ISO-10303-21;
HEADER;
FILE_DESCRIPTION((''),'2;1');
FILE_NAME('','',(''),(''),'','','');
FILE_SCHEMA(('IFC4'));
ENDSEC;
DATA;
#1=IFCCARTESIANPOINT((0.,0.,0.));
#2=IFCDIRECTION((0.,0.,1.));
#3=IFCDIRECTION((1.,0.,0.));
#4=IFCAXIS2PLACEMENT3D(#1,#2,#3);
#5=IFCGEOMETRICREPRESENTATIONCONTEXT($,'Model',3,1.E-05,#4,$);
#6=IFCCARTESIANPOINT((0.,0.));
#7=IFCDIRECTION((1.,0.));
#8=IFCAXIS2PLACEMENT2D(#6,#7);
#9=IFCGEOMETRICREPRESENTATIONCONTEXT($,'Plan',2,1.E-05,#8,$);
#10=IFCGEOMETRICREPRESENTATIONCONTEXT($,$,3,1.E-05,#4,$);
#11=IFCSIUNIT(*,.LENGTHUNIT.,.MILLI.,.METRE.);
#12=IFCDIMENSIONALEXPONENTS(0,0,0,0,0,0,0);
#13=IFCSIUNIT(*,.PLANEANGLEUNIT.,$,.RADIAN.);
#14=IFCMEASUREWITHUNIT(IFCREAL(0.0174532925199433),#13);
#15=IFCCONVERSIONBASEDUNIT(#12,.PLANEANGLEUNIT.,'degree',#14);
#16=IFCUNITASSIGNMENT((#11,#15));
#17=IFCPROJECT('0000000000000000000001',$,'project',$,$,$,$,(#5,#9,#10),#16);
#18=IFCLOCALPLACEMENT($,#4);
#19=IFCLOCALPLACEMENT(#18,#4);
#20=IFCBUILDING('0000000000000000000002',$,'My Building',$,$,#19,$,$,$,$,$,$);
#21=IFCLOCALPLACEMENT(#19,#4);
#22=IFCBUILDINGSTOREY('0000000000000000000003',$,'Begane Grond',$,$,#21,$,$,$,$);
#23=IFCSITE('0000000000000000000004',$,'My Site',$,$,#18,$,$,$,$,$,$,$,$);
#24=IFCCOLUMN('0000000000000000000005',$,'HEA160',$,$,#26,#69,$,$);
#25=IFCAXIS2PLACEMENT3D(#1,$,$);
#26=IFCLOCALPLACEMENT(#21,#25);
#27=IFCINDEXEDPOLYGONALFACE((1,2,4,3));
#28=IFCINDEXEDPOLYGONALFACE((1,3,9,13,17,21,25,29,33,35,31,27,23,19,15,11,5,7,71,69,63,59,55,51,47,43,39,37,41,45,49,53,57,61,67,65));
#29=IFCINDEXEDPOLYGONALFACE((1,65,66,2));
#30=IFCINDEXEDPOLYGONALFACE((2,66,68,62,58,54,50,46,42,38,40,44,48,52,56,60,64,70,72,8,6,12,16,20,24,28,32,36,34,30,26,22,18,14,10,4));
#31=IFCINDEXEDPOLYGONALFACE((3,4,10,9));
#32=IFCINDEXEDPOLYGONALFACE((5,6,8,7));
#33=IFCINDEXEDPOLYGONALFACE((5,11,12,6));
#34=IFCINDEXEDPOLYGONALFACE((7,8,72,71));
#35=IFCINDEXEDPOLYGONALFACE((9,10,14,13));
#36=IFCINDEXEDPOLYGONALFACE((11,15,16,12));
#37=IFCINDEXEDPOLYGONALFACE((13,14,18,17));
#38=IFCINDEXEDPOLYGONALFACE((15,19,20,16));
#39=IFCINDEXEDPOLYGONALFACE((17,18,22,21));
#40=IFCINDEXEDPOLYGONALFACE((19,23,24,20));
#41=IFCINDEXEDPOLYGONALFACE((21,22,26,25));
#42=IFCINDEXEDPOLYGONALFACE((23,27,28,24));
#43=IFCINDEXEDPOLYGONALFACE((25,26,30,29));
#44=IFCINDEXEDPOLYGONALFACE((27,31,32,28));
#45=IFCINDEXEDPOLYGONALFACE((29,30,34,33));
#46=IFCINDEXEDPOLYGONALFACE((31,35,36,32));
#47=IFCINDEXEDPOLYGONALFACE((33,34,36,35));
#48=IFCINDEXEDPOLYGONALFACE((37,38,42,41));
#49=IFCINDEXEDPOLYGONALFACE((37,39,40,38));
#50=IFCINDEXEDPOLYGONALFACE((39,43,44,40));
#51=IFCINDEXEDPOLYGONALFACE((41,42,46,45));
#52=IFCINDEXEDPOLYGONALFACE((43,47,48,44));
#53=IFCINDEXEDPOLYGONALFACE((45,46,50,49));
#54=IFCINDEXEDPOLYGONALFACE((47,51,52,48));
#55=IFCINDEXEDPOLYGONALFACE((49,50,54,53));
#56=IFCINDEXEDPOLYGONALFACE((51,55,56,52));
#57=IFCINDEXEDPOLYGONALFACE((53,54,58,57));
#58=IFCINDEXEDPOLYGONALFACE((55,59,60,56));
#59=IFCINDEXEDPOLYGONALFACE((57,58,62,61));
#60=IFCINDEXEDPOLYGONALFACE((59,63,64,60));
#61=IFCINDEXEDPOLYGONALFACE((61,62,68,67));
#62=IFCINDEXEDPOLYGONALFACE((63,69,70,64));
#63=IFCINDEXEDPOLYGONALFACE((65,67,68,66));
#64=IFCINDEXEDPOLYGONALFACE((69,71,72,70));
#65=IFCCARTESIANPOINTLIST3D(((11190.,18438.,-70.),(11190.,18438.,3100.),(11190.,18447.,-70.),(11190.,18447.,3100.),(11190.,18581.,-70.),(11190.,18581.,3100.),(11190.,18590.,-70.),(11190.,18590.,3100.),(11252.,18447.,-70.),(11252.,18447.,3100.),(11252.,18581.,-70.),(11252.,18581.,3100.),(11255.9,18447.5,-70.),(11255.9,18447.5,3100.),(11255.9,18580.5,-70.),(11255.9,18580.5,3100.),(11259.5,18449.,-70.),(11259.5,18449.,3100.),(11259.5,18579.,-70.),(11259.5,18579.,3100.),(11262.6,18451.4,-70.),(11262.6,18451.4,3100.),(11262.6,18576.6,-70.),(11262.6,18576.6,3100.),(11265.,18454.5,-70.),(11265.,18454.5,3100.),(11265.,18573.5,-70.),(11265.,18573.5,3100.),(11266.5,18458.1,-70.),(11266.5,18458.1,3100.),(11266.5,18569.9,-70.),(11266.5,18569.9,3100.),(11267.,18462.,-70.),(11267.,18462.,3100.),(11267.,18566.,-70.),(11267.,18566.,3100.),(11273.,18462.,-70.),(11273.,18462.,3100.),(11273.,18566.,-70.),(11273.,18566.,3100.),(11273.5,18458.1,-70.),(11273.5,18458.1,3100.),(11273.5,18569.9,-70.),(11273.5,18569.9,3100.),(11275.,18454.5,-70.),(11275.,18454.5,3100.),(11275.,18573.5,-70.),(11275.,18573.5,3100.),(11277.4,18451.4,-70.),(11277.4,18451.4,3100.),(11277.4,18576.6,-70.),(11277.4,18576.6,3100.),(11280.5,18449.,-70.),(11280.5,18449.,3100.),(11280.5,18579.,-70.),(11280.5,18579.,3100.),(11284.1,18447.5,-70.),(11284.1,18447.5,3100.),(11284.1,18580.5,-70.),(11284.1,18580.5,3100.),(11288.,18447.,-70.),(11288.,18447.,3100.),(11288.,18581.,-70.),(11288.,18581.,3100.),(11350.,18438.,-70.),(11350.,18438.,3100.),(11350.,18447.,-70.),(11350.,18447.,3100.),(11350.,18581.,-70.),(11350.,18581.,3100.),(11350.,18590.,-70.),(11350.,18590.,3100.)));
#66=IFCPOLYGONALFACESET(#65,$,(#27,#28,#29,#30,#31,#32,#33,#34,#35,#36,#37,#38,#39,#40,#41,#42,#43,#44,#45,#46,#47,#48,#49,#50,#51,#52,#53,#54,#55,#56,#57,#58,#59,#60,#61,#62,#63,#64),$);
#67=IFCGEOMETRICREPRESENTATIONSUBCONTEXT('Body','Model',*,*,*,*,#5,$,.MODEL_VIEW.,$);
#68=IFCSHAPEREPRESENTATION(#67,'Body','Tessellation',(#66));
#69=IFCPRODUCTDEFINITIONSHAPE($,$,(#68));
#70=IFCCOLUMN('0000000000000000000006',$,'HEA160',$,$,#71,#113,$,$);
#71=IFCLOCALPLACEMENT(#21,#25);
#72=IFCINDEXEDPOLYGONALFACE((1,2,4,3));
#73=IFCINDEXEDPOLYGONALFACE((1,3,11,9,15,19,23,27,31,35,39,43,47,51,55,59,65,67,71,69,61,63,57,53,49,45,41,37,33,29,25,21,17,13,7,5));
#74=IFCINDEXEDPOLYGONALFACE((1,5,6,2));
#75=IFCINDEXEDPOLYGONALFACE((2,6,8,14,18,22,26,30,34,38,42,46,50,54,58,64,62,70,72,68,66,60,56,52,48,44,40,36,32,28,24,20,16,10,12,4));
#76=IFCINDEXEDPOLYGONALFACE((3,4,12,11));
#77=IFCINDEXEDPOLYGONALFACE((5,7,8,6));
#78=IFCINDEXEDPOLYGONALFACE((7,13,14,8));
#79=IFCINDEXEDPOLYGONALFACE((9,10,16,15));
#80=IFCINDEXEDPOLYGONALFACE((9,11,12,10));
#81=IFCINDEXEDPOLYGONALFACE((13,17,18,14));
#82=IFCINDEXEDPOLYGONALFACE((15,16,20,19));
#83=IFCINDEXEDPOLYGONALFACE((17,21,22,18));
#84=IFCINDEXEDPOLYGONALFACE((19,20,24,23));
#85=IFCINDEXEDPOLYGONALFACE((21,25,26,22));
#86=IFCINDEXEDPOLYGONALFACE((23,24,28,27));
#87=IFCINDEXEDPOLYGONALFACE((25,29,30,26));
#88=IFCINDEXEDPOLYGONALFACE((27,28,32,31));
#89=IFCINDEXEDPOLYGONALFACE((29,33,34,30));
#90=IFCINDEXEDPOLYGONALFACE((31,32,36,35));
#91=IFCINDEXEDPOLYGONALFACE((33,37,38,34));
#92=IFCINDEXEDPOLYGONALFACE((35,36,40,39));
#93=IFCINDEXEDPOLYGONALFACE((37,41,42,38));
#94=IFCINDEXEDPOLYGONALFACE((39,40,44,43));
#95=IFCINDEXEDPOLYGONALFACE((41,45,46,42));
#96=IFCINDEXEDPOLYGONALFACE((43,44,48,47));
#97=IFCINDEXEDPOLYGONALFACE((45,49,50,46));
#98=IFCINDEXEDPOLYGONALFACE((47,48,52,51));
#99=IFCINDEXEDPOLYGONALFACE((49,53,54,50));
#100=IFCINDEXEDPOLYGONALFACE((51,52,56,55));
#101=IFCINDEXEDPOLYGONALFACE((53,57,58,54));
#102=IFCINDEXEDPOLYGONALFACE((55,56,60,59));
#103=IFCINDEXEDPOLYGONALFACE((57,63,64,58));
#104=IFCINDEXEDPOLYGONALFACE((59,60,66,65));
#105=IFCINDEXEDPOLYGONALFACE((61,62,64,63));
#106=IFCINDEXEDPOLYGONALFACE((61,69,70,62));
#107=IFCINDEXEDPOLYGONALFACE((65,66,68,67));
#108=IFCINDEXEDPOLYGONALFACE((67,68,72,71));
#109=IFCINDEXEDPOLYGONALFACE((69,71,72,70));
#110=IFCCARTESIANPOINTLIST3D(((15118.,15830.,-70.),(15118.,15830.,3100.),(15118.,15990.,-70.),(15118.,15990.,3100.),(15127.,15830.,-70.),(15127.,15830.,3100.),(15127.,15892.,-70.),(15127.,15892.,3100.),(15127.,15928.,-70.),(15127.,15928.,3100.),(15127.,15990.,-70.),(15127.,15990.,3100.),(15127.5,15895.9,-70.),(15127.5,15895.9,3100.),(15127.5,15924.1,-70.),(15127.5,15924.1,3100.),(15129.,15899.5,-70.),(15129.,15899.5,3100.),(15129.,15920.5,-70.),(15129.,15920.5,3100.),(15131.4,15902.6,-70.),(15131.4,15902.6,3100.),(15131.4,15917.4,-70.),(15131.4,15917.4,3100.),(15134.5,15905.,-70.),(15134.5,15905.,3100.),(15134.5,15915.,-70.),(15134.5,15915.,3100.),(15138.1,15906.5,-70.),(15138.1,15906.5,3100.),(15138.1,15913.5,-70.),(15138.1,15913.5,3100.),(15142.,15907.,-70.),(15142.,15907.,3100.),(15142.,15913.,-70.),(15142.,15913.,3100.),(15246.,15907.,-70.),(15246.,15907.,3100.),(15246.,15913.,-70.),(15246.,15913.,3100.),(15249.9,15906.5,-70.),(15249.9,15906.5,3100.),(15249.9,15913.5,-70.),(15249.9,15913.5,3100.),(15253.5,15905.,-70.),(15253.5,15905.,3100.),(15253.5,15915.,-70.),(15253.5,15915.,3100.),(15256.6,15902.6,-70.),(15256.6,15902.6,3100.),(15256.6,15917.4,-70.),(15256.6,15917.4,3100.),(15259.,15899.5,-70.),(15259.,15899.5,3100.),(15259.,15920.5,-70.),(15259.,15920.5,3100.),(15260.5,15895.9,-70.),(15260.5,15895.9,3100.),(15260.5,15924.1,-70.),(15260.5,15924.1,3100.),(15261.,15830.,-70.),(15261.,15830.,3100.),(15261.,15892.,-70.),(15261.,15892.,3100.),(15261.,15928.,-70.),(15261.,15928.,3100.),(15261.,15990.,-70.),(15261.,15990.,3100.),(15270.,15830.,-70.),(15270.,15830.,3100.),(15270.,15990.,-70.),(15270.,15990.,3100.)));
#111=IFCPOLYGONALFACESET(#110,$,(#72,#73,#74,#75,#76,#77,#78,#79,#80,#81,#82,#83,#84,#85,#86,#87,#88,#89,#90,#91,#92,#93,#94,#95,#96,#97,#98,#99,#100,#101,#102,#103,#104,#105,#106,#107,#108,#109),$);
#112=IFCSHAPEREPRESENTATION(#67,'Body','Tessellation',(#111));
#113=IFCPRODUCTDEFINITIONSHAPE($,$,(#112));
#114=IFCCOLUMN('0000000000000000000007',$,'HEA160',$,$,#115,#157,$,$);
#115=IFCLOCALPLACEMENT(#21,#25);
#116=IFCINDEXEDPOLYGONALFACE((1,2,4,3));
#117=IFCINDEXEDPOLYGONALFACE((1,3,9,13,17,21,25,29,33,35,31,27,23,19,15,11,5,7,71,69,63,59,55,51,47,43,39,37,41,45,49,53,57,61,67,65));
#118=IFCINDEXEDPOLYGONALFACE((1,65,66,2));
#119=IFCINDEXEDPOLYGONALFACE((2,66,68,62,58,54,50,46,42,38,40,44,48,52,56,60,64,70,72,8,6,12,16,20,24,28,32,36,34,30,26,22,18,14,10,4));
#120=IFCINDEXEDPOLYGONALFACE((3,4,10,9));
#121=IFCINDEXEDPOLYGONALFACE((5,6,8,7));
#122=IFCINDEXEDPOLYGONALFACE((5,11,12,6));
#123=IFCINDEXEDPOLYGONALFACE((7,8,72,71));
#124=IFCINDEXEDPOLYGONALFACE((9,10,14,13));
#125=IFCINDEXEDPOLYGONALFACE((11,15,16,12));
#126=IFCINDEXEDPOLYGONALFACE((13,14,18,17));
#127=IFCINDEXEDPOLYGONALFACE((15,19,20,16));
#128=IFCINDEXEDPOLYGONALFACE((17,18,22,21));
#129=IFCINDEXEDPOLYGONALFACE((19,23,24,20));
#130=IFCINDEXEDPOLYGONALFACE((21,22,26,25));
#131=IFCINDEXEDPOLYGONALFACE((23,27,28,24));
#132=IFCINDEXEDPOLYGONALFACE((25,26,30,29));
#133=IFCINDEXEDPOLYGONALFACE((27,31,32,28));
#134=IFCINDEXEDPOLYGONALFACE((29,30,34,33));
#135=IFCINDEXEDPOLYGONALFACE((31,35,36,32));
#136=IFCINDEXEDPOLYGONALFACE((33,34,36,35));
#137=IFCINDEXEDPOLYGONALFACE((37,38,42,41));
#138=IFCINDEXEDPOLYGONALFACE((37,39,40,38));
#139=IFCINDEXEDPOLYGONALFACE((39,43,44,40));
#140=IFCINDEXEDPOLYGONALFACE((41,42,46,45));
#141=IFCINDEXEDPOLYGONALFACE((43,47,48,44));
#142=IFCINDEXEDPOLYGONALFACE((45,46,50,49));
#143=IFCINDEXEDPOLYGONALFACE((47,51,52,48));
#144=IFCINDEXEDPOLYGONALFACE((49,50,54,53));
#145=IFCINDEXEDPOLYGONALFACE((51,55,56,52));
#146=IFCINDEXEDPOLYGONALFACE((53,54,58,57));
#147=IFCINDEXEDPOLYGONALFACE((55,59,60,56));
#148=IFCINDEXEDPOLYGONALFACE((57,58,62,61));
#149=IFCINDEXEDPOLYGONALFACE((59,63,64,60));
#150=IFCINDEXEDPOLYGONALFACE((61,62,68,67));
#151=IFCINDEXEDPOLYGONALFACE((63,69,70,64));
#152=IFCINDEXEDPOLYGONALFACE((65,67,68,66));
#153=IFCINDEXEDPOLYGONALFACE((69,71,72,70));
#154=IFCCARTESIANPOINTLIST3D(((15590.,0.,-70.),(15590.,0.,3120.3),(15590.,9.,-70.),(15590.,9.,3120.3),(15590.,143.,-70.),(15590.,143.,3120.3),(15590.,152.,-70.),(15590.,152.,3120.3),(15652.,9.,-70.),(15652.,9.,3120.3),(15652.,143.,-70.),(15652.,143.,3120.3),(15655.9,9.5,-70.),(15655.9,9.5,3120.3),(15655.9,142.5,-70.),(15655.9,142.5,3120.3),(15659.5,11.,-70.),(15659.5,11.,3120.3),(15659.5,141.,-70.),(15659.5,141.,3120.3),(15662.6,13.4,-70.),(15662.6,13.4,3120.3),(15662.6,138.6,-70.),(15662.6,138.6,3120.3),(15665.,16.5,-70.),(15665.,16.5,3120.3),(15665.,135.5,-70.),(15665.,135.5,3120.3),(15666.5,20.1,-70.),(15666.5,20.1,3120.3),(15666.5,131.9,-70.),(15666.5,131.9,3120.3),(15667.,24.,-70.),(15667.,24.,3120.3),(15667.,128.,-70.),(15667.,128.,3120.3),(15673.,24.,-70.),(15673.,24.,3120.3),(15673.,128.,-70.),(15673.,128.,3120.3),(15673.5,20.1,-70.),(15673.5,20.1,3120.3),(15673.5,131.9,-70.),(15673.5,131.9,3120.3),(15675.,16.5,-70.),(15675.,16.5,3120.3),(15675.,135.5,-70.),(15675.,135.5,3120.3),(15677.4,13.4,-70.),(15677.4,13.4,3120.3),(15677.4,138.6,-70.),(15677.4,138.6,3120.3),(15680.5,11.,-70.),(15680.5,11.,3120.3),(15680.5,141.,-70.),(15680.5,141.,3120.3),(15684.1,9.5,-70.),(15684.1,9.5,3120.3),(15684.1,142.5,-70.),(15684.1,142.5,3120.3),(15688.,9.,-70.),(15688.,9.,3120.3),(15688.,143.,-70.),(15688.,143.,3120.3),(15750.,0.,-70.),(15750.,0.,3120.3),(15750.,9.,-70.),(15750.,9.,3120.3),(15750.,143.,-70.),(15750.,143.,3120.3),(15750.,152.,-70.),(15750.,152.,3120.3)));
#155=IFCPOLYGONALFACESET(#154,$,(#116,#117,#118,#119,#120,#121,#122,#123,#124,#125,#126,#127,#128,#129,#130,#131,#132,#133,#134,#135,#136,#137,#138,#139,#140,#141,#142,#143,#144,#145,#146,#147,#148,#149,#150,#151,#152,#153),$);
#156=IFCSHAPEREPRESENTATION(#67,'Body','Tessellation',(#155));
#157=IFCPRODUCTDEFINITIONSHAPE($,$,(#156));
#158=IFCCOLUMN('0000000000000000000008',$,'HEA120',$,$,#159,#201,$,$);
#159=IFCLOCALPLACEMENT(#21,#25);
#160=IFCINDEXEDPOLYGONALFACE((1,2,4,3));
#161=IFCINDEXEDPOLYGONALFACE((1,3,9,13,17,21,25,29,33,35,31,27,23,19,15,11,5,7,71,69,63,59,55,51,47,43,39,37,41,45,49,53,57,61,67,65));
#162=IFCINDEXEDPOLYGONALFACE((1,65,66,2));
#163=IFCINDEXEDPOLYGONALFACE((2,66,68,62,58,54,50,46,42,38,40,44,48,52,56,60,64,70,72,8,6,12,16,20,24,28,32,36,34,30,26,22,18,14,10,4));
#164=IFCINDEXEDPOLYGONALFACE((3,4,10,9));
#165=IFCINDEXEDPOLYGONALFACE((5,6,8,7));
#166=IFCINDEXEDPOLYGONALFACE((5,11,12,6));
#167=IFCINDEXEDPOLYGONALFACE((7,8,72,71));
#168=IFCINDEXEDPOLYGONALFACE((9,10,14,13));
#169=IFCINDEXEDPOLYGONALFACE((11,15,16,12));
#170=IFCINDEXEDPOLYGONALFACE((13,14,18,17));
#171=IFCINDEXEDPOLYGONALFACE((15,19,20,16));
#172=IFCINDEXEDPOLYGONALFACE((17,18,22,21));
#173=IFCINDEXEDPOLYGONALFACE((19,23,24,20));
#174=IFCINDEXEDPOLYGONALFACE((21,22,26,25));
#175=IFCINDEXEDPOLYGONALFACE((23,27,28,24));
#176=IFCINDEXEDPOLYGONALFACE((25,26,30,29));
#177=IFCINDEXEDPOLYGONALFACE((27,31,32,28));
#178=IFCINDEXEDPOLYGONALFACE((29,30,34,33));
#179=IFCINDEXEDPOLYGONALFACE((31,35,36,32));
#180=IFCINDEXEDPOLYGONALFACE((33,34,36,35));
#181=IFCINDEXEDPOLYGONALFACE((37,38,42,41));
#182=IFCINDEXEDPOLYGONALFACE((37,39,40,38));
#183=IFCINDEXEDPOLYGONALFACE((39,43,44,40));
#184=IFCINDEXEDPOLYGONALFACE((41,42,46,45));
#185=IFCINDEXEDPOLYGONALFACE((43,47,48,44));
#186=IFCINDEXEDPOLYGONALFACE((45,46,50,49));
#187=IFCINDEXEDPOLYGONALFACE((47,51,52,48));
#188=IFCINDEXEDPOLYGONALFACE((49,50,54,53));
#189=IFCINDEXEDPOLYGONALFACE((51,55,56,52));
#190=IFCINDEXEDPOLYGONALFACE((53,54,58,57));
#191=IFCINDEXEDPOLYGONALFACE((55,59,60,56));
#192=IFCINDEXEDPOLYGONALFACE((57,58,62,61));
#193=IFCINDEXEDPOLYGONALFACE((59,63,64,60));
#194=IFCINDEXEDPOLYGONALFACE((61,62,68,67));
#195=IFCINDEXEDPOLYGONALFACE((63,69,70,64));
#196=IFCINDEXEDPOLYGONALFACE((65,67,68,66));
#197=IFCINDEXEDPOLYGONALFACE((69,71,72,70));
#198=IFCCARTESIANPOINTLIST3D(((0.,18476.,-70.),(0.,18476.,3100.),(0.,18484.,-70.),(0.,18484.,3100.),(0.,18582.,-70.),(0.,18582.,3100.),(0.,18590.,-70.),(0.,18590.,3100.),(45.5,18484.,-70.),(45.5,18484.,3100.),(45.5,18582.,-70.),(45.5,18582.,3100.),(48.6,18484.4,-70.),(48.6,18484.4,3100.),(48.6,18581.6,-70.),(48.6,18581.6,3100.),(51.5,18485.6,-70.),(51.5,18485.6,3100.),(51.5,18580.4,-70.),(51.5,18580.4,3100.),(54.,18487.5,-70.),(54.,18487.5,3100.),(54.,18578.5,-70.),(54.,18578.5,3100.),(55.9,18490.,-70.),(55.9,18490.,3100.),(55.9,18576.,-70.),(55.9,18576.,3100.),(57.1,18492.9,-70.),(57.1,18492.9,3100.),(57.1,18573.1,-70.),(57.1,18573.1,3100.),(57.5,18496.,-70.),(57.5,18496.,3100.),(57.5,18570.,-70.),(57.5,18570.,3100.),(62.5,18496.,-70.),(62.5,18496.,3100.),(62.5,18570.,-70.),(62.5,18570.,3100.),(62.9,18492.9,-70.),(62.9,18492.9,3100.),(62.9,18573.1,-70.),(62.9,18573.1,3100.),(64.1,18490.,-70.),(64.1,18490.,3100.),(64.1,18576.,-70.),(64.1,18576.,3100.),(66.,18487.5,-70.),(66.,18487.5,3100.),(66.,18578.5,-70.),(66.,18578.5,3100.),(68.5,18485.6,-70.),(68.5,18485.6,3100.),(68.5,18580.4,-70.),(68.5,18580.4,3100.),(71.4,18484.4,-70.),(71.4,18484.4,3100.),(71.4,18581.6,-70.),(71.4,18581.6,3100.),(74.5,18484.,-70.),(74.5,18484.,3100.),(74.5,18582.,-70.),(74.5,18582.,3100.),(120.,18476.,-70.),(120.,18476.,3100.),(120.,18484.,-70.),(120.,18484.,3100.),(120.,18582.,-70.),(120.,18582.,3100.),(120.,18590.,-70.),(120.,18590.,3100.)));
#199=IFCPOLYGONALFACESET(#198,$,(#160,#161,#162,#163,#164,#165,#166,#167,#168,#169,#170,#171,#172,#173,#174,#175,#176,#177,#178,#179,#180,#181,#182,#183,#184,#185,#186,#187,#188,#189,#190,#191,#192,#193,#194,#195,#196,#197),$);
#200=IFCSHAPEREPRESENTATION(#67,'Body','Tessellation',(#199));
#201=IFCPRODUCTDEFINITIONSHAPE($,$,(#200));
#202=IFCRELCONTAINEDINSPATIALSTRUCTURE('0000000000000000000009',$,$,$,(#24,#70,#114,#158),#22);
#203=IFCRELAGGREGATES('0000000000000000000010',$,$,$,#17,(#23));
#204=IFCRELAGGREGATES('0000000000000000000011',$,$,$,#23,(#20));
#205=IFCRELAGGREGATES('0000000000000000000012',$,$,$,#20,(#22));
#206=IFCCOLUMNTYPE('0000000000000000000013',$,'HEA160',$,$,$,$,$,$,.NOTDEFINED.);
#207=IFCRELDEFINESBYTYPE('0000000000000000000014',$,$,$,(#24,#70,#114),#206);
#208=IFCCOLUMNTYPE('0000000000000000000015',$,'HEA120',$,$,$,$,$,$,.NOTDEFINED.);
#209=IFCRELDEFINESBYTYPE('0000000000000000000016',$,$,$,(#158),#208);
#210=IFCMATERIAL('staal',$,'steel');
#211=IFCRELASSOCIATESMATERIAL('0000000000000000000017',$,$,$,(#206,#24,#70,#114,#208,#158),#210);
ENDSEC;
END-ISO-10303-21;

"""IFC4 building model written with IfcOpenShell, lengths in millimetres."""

from ifc_helpers import new_model, entity, si_unit, converted_unit, frame, origin_with_axes, origin_2d_with_axis, place, context, subcontext, project, spatial, i_section, extrude, material, material_profile, profile_set, profile_usage, type_object, element, save


model = new_model("IFC4")

# Units and contexts
model_context = context("Model", 3, precision=1e-05, world=origin_with_axes())
plan_context = context("Plan", 2, precision=1e-05, world=origin_2d_with_axis())
context_of_model = context(None, 3, precision=1e-05, world=origin_with_axes())
body_context = subcontext(model_context, "Body", "Model", "MODEL_VIEW")
ifc_project = project(units=[si_unit("LENGTHUNIT", "METRE", prefix="MILLI"), converted_unit("PLANEANGLEUNIT", "degree", entity("IfcReal", 0.0174532925199433), si_unit("PLANEANGLEUNIT", "RADIAN"), dimensions=[0, 0, 0, 0, 0, 0, 0])], contexts=[model_context, plan_context, context_of_model])

# Site, building, storey
site_placement = place(None, origin_with_axes())
site = spatial("IfcSite", under=ifc_project, at=site_placement, Name="My Site")
building_placement = place(site_placement, origin_with_axes())
building = spatial("IfcBuilding", under=site, at=building_placement, Name="My Building")
storey_placement = place(building_placement, origin_with_axes())
storey = spatial("IfcBuildingStorey", under=building, at=storey_placement, Name="Begane Grond")

# Columns
ifc_material = material(Name="staal", Category="steel")
ifc_material_profile_1 = material_profile(ifc_material, i_section(OverallWidth=160.0, OverallDepth=152.0, WebThickness=6.0, FlangeThickness=9.0, FilletRadius=15.0))
ifc_profile_set_1 = profile_set([ifc_material_profile_1], Name="HEA160")
column_type_1 = type_object("IfcColumnType", Name="HEA160", PredefinedType="NOTDEFINED", material=ifc_profile_set_1)
ifc_profile_usage_1 = profile_usage(ifc_profile_set_1)
column_1_placement = place(storey_placement, frame((11270.0, 18514.0, -70.0), z_axis=(0.0, 0.0, 1.0), x_axis=(1.0, 0.0, 0.0)))
element("IfcColumn", 1, at=column_1_placement, inside=storey, type_object=column_type_1, material=ifc_profile_usage_1, Name="HEA160", context=body_context, shape_type="SweptSolid", body=[
    extrude(i_section(OverallWidth=160.0, OverallDepth=152.0, WebThickness=6.0, FlangeThickness=9.0, FilletRadius=15.0), origin_with_axes(), (0.0, 0.0, 1.0), 3170.0),
])
ifc_profile_usage_2 = profile_usage(ifc_profile_set_1)
column_2_placement = place(storey_placement, frame((15194.0, 15910.0, -70.0), z_axis=(0.0, 0.0, 1.0), x_axis=(0.0, 1.0, 0.0)))
element("IfcColumn", 2, at=column_2_placement, inside=storey, type_object=column_type_1, material=ifc_profile_usage_2, Name="HEA160", context=body_context, shape_type="SweptSolid", body=[
    extrude(i_section(OverallWidth=160.0, OverallDepth=152.0, WebThickness=6.0, FlangeThickness=9.0, FilletRadius=15.0), origin_with_axes(), (0.0, 0.0, 1.0), 3170.0),
])
ifc_profile_usage_3 = profile_usage(ifc_profile_set_1)
column_3_placement = place(storey_placement, frame((15670.0, 76.0, -70.0), z_axis=(0.0, 0.0, 1.0), x_axis=(-1.0, 0.0, 0.0)))
element("IfcColumn", 3, at=column_3_placement, inside=storey, type_object=column_type_1, material=ifc_profile_usage_3, Name="HEA160", context=body_context, shape_type="SweptSolid", body=[
    extrude(i_section(OverallWidth=160.0, OverallDepth=152.0, WebThickness=6.0, FlangeThickness=9.0, FilletRadius=15.0), origin_with_axes(), (0.0, 0.0, 1.0), 3190.3),
])
ifc_material_profile_2 = material_profile(ifc_material, i_section(OverallWidth=120.0, OverallDepth=114.0, WebThickness=5.0, FlangeThickness=8.0, FilletRadius=12.0))
ifc_profile_set_2 = profile_set([ifc_material_profile_2], Name="HEA120")
ifc_profile_usage_4 = profile_usage(ifc_profile_set_2, cardinal=8)
column_type_2 = type_object("IfcColumnType", Name="HEA120", PredefinedType="NOTDEFINED", material=ifc_profile_set_2)
column_4_placement = place(storey_placement, frame((60.0, 18590.0, -70.0), z_axis=(0.0, 0.0, 1.0), x_axis=(1.0, 0.0, 0.0)))
element("IfcColumn", 4, at=column_4_placement, inside=storey, type_object=column_type_2, material=ifc_profile_usage_4, Name="HEA120", context=body_context, shape_type="SweptSolid", body=[
    extrude(i_section(OverallWidth=120.0, OverallDepth=114.0, WebThickness=5.0, FlangeThickness=8.0, FilletRadius=12.0), frame((0.0, -57.0, 0.0), z_axis=(0.0, 0.0, 1.0), x_axis=(1.0, 0.0, 0.0)), (0.0, 0.0, 1.0), 3170.0),
])

save(model, "model.ifc")
